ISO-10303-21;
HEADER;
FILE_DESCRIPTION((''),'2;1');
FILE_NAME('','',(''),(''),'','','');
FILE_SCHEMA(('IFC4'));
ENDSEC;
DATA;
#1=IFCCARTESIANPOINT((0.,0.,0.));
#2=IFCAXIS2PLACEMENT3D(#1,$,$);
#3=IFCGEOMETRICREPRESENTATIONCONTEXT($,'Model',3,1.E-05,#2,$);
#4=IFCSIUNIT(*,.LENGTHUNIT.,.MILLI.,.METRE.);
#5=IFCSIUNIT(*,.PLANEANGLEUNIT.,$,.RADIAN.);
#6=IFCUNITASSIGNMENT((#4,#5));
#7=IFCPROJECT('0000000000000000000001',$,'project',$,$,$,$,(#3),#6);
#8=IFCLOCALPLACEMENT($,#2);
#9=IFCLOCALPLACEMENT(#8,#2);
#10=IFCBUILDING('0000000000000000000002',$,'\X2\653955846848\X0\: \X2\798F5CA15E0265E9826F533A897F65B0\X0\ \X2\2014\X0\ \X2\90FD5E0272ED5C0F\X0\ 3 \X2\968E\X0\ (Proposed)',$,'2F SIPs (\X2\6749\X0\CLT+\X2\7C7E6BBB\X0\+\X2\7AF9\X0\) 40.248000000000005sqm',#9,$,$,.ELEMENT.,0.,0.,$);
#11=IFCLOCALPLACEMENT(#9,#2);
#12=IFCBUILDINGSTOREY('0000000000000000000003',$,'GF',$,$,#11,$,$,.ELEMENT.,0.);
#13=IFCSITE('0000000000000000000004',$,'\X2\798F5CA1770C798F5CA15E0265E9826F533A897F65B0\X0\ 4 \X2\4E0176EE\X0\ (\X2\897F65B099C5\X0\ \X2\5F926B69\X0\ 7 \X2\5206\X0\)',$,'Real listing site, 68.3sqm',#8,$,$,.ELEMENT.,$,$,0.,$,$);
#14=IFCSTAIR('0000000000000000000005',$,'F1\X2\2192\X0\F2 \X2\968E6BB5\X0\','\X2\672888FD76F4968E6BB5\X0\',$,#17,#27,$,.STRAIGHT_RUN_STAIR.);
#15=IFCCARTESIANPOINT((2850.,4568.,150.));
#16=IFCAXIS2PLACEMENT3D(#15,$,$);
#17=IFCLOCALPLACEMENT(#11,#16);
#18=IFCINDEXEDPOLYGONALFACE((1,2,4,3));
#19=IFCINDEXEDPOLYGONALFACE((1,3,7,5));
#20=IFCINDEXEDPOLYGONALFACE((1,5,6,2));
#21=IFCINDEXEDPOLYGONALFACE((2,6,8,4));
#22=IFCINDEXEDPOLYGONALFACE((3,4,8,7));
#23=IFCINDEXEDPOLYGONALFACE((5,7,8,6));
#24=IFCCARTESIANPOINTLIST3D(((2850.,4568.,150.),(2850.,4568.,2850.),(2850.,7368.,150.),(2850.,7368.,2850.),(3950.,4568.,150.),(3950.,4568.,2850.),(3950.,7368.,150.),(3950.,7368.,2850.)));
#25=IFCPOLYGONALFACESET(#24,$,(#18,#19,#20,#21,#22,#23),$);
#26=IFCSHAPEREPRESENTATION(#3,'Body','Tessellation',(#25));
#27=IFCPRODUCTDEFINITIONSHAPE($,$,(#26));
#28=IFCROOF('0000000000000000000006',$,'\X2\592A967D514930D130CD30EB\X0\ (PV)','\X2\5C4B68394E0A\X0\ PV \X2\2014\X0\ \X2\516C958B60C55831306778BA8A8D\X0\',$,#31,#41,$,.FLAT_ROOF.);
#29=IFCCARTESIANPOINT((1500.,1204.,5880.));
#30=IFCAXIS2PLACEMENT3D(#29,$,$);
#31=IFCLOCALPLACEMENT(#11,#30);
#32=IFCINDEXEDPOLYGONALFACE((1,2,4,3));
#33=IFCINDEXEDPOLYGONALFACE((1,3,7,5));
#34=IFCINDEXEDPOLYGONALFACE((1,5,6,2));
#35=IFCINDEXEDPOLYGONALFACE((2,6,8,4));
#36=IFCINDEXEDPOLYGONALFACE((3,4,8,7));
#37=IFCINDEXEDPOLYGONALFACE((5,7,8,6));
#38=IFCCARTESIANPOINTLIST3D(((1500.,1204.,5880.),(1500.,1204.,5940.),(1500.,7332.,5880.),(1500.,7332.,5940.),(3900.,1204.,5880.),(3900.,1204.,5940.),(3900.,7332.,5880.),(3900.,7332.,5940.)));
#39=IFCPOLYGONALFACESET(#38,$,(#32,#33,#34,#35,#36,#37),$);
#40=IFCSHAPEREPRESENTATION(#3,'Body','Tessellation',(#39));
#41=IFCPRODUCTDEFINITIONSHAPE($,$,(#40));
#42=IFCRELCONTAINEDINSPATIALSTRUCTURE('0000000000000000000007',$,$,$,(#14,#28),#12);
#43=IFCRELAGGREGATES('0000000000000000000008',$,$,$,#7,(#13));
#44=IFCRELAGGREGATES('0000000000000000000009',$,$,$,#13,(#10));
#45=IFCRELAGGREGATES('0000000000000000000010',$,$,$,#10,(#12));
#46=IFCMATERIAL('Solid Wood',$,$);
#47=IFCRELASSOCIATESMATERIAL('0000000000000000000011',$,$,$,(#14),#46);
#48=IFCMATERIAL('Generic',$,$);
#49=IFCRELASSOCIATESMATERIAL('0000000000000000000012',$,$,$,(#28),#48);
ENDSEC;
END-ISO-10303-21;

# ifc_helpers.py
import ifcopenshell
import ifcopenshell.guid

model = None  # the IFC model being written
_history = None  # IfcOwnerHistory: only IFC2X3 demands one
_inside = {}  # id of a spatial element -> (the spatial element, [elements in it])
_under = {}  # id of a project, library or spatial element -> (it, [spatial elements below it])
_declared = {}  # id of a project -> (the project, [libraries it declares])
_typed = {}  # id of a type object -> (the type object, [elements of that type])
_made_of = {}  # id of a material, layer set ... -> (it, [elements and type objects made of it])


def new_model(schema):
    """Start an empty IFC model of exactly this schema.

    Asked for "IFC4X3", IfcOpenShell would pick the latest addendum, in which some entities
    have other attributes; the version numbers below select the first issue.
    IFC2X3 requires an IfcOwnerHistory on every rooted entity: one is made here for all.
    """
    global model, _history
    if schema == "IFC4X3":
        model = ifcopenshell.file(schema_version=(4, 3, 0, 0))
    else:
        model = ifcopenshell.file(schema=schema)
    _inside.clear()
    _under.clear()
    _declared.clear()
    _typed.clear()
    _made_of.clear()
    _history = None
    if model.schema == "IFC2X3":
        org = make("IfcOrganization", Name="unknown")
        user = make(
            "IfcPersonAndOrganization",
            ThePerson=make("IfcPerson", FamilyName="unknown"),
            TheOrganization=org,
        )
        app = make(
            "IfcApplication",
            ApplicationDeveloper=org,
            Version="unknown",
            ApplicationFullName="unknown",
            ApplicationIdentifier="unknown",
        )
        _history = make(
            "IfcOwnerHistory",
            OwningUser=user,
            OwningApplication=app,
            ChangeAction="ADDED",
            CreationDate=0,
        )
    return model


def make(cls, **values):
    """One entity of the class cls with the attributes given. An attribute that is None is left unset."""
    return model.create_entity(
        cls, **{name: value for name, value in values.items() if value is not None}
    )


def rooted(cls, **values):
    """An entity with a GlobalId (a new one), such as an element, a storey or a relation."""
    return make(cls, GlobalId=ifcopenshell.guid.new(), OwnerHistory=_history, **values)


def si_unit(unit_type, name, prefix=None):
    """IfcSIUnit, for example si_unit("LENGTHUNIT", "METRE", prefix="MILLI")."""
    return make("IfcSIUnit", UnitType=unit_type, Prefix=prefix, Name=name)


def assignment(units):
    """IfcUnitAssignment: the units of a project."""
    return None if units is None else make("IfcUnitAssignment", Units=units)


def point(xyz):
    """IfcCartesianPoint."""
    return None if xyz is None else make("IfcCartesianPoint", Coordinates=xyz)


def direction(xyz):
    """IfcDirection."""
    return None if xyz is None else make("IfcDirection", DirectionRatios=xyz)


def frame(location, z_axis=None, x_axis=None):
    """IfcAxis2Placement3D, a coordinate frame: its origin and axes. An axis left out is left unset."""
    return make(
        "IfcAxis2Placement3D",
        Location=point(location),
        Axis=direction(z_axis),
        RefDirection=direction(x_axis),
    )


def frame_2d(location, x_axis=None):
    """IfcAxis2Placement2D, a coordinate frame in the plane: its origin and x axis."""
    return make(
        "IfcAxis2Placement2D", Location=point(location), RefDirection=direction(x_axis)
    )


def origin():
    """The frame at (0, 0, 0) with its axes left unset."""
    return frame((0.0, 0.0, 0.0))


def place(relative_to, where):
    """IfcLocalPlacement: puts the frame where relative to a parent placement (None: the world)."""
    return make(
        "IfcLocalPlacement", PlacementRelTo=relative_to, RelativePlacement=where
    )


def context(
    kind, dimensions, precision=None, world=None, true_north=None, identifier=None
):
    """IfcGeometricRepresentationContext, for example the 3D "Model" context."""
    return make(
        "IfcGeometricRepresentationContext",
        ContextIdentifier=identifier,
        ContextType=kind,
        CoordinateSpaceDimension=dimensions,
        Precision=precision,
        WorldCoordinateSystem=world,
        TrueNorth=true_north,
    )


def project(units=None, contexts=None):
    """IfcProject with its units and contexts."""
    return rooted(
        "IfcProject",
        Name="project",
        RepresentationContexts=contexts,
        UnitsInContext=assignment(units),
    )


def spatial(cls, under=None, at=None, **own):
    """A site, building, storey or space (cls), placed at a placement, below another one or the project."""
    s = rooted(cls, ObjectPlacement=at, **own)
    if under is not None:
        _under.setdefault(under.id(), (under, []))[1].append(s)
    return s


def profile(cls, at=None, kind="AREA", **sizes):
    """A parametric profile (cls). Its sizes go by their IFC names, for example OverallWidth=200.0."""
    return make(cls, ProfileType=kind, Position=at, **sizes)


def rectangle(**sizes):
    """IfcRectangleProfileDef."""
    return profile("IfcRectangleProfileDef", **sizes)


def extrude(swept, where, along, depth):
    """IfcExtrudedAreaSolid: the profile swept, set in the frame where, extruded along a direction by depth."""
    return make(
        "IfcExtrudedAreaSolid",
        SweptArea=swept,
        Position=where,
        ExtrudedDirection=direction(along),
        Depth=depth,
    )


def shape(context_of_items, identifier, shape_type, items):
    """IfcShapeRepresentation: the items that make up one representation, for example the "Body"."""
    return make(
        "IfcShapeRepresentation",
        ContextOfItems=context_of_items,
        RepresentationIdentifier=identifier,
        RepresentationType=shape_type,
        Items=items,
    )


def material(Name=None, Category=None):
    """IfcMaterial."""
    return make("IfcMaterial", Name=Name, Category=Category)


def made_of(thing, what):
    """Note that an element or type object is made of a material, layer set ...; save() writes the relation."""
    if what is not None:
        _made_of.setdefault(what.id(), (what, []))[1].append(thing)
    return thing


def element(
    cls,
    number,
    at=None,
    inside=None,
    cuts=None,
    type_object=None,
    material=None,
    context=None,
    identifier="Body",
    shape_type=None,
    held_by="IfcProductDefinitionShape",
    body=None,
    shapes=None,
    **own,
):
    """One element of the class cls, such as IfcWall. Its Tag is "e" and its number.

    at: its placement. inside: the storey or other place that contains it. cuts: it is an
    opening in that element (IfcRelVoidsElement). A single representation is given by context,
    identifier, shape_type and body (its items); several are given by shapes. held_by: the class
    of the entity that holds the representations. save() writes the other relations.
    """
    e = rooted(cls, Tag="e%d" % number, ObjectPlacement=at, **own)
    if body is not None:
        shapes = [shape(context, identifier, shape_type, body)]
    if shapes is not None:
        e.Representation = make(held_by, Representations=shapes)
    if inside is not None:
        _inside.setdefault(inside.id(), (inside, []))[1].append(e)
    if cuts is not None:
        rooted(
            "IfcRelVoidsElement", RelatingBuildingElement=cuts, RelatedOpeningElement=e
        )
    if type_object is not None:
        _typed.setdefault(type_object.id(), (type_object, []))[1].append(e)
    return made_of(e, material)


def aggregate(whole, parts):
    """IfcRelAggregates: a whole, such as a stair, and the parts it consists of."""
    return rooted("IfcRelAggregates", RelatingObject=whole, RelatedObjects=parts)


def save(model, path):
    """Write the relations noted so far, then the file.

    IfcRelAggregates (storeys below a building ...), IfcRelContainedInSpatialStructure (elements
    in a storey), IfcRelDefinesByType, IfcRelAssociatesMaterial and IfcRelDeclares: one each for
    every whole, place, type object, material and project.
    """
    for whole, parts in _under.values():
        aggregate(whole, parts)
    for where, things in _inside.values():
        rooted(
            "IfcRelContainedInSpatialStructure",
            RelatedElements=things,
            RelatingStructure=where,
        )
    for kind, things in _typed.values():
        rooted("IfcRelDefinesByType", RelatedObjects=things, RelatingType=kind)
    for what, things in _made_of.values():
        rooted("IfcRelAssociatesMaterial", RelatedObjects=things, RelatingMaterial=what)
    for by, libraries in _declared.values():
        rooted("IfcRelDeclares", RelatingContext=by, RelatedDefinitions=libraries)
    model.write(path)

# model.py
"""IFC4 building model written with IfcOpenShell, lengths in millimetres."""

from ifc_helpers import new_model, si_unit, frame, frame_2d, origin, place, context, project, spatial, rectangle, extrude, material, element, save


model = new_model("IFC4")

# Units and contexts
model_context = context("Model", 3, precision=1e-05, world=origin())
ifc_project = project(units=[si_unit("LENGTHUNIT", "METRE", prefix="MILLI"), si_unit("PLANEANGLEUNIT", "RADIAN")], contexts=[model_context])

# Site, building, storey
site_placement = place(None, origin())
site = spatial("IfcSite", under=ifc_project, at=site_placement, Name="福岡県福岡市早良区西新 4 丁目 (西新駅 徒歩 7 分)", ObjectType="Real listing site, 68.3sqm", CompositionType="ELEMENT", RefElevation=0.0)
building_placement = place(site_placement, origin())
building = spatial("IfcBuilding", under=site, at=building_placement, Name="改善案: 福岡市早良区西新 — 都市狭小 3 階 (Proposed)", ObjectType="2F SIPs (杉CLT+籾殻+竹) 40.248000000000005sqm", CompositionType="ELEMENT", ElevationOfRefHeight=0.0, ElevationOfTerrain=0.0)
storey_placement = place(building_placement, origin())
storey = spatial("IfcBuildingStorey", under=building, at=storey_placement, Name="GF", CompositionType="ELEMENT", Elevation=0.0)

# Shared definitions
ifc_material_1 = material(Name="Generic")

# Stair
ifc_material_2 = material(Name="Solid Wood")
stair_placement = place(storey_placement, frame((2850.0, 4568.0, 150.0)))
element("IfcStair", 1, at=stair_placement, inside=storey, material=ifc_material_2, Name="F1→F2 階段", Description="木製直階段", PredefinedType="STRAIGHT_RUN_STAIR", context=model_context, shape_type="SweptSolid", body=[
    extrude(rectangle(XDim=1100.0, YDim=2800.0, at=frame_2d((550.0, 1400.0))), frame((2850.0, 4568.0, 150.0)), (0.0, 0.0, 1.0), 2700.0),
])

# Roof
roof_placement = place(storey_placement, frame((1500.0, 1204.0, 5880.0)))
element("IfcRoof", 2, at=roof_placement, inside=storey, material=ifc_material_1, Name="太陽光パネル (PV)", Description="屋根上 PV — 公開情報で確認", PredefinedType="FLAT_ROOF", context=model_context, shape_type="SweptSolid", body=[
    extrude(rectangle(XDim=2400.0, YDim=6128.0, at=frame_2d((1200.0, 3064.0))), frame((1500.0, 1204.0, 5880.0)), (0.0, 0.0, 1.0), 60.0),
])

save(model, "model.ifc")
